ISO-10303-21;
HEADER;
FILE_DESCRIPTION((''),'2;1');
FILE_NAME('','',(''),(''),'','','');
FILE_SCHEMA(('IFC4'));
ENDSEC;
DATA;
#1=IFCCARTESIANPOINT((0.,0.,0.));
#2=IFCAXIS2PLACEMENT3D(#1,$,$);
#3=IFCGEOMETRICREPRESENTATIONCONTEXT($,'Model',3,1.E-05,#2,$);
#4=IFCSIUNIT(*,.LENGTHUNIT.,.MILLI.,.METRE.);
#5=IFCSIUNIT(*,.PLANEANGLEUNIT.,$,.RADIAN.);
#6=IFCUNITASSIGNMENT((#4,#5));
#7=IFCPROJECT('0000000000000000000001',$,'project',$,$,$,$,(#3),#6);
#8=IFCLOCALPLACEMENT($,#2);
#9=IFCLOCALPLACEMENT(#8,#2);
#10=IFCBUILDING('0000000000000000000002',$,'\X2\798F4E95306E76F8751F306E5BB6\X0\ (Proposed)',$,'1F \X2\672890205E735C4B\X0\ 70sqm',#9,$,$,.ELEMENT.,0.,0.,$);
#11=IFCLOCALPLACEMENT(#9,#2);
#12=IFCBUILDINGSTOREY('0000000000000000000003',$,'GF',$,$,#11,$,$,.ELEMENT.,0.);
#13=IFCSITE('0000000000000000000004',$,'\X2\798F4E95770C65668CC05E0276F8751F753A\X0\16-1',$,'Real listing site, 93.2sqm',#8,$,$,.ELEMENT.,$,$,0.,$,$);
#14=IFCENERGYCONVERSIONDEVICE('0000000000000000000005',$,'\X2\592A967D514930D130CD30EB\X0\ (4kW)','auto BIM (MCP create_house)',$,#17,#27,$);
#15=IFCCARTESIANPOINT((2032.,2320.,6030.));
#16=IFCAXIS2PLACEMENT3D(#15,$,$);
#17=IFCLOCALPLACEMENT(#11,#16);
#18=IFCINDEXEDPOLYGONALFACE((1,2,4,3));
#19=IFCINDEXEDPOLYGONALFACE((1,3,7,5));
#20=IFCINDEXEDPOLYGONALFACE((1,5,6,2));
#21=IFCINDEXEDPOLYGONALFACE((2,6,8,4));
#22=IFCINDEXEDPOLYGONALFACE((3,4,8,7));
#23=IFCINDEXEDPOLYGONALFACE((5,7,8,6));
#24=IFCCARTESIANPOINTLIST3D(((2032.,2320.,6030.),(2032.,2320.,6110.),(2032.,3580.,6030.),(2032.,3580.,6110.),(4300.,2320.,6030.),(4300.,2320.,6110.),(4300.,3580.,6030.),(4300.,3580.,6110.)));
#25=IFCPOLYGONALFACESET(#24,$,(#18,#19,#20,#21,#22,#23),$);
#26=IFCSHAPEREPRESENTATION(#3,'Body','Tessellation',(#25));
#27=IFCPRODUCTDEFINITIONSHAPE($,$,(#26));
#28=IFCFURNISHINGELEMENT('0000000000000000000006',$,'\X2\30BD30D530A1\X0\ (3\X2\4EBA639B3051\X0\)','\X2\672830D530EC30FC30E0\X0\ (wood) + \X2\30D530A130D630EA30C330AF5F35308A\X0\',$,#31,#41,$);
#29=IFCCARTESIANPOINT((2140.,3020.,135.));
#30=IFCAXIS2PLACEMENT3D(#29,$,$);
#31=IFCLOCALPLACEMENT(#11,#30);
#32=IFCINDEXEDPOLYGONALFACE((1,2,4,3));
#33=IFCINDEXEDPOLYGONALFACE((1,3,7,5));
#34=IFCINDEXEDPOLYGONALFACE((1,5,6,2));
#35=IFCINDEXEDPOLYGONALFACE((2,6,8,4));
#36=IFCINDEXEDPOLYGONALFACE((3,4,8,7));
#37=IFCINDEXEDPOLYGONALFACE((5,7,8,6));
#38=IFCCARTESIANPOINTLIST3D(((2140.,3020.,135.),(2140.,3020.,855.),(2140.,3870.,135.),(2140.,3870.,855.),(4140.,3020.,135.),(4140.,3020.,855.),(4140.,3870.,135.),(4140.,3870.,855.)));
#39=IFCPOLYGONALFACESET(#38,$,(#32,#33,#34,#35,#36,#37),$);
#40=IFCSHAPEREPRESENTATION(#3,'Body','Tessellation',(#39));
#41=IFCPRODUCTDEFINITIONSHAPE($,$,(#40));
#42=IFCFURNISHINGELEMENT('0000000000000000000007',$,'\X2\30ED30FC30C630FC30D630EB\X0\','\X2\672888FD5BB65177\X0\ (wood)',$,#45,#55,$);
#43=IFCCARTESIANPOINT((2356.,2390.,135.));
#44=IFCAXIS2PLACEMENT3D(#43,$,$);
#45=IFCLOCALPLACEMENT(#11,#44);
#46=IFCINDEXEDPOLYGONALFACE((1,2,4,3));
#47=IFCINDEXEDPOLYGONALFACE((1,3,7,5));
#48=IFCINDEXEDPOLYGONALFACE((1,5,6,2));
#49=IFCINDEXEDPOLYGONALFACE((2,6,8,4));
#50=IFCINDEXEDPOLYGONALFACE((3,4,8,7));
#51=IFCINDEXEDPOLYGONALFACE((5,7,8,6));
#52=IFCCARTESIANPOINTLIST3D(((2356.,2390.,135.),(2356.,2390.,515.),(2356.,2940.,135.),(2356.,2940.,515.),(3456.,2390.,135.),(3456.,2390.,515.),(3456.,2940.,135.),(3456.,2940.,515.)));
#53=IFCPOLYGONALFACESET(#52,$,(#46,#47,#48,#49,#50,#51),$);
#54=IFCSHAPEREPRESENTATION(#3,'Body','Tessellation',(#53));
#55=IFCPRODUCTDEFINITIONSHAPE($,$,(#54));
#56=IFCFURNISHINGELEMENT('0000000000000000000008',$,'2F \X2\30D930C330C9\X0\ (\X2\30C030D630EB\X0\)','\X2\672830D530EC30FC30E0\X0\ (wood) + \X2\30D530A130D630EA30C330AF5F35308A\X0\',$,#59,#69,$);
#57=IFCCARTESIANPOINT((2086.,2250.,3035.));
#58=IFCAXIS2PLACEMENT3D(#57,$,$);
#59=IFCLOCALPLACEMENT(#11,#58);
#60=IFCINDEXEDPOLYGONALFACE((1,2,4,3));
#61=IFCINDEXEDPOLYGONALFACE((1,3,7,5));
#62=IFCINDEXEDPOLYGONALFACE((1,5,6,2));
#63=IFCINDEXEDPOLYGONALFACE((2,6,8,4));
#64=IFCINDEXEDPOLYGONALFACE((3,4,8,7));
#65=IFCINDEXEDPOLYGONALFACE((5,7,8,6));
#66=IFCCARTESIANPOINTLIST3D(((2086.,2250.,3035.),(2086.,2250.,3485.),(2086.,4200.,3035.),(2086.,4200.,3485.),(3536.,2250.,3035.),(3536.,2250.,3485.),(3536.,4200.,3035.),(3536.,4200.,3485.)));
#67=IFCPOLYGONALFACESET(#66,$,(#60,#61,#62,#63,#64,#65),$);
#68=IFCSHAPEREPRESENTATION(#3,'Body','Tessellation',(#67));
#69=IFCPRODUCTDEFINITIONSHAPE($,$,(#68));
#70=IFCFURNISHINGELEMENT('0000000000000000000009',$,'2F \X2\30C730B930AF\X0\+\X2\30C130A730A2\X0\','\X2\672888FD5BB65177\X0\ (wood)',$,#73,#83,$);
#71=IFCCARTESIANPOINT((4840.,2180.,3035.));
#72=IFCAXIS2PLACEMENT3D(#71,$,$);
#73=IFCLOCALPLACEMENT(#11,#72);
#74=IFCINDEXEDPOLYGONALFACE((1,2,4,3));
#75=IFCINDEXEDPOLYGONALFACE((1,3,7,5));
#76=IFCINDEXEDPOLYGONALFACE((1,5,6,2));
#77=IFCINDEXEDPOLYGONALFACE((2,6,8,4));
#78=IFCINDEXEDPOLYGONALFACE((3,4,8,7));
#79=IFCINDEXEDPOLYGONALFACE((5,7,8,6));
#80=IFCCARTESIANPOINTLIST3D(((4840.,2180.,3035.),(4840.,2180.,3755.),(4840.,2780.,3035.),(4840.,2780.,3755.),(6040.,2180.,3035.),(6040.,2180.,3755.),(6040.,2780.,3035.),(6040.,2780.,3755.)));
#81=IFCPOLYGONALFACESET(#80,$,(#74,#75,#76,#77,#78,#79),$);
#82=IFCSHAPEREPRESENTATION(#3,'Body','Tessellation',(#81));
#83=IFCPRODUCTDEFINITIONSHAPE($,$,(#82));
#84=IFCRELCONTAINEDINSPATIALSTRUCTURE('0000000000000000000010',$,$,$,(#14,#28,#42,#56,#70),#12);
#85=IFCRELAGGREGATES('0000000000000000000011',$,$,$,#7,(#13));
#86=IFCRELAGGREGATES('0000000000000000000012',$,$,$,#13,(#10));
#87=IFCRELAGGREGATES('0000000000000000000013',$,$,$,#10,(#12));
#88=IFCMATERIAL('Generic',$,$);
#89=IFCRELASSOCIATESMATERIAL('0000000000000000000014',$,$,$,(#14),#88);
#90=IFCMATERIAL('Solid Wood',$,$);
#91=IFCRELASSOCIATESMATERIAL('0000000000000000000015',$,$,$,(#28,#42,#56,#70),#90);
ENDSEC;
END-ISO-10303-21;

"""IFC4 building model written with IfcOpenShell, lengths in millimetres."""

from ifc_helpers import new_model, si_unit, frame, frame_2d, origin, place, context, project, spatial, rectangle, extrude, material, element, save


model = new_model("IFC4")

# Units and contexts
model_context = context("Model", 3, precision=1e-05, world=origin())
ifc_project = project(units=[si_unit("LENGTHUNIT", "METRE", prefix="MILLI"), si_unit("PLANEANGLEUNIT", "RADIAN")], contexts=[model_context])

# Site, building, storey
site_placement = place(None, origin())
site = spatial("IfcSite", under=ifc_project, at=site_placement, Name="福井県敦賀市相生町16-1", ObjectType="Real listing site, 93.2sqm", CompositionType="ELEMENT", RefElevation=0.0)
building_placement = place(site_placement, origin())
building = spatial("IfcBuilding", under=site, at=building_placement, Name="福井の相生の家 (Proposed)", ObjectType="1F 木造平屋 70sqm", CompositionType="ELEMENT", ElevationOfRefHeight=0.0, ElevationOfTerrain=0.0)
storey_placement = place(building_placement, origin())
storey = spatial("IfcBuildingStorey", under=building, at=storey_placement, Name="GF", CompositionType="ELEMENT", Elevation=0.0)

# Shared definitions
ifc_material_1 = material(Name="Solid Wood")

# Shared definitions
ifc_material_2 = material(Name="Generic")

# Energy conversion device
energy_conversion_device_placement = place(storey_placement, frame((2032.0, 2320.0, 6030.0)))
element("IfcEnergyConversionDevice", 1, at=energy_conversion_device_placement, inside=storey, material=ifc_material_2, Name="太陽光パネル (4kW)", Description="auto BIM (MCP create_house)", context=model_context, shape_type="SweptSolid", body=[
    extrude(rectangle(XDim=2268.0, YDim=1260.0, at=frame_2d((1134.0, 630.0))), frame((2032.0, 2320.0, 6030.0)), (0.0, 0.0, 1.0), 80.0),
])

# Furnishing elements
furnishing_1_placement = place(storey_placement, frame((2140.0, 3020.0, 135.0)))
element("IfcFurnishingElement", 2, at=furnishing_1_placement, inside=storey, material=ifc_material_1, Name="ソファ (3人掛け)", Description="木フレーム (wood) + ファブリック張り", context=model_context, shape_type="SweptSolid", body=[
    extrude(rectangle(XDim=2000.0, YDim=850.0, at=frame_2d((1000.0, 425.0))), frame((2140.0, 3020.0, 135.0)), (0.0, 0.0, 1.0), 720.0),
])
furnishing_2_placement = place(storey_placement, frame((2356.0, 2390.0, 135.0)))
element("IfcFurnishingElement", 3, at=furnishing_2_placement, inside=storey, material=ifc_material_1, Name="ローテーブル", Description="木製家具 (wood)", context=model_context, shape_type="SweptSolid", body=[
    extrude(rectangle(XDim=1100.0, YDim=550.0, at=frame_2d((550.0, 275.0))), frame((2356.0, 2390.0, 135.0)), (0.0, 0.0, 1.0), 380.0),
])
furnishing_3_placement = place(storey_placement, frame((2086.0, 2250.0, 3035.0)))
element("IfcFurnishingElement", 4, at=furnishing_3_placement, inside=storey, material=ifc_material_1, Name="2F ベッド (ダブル)", Description="木フレーム (wood) + ファブリック張り", context=model_context, shape_type="SweptSolid", body=[
    extrude(rectangle(XDim=1450.0, YDim=1950.0, at=frame_2d((725.0, 975.0))), frame((2086.0, 2250.0, 3035.0)), (0.0, 0.0, 1.0), 450.0),
])
furnishing_4_placement = place(storey_placement, frame((4840.0, 2180.0, 3035.0)))
element("IfcFurnishingElement", 5, at=furnishing_4_placement, inside=storey, material=ifc_material_1, Name="2F デスク+チェア", Description="木製家具 (wood)", context=model_context, shape_type="SweptSolid", body=[
    extrude(rectangle(XDim=1200.0, YDim=600.0, at=frame_2d((600.0, 300.0))), frame((4840.0, 2180.0, 3035.0)), (0.0, 0.0, 1.0), 720.0),
])

save(model, "model.ifc")
